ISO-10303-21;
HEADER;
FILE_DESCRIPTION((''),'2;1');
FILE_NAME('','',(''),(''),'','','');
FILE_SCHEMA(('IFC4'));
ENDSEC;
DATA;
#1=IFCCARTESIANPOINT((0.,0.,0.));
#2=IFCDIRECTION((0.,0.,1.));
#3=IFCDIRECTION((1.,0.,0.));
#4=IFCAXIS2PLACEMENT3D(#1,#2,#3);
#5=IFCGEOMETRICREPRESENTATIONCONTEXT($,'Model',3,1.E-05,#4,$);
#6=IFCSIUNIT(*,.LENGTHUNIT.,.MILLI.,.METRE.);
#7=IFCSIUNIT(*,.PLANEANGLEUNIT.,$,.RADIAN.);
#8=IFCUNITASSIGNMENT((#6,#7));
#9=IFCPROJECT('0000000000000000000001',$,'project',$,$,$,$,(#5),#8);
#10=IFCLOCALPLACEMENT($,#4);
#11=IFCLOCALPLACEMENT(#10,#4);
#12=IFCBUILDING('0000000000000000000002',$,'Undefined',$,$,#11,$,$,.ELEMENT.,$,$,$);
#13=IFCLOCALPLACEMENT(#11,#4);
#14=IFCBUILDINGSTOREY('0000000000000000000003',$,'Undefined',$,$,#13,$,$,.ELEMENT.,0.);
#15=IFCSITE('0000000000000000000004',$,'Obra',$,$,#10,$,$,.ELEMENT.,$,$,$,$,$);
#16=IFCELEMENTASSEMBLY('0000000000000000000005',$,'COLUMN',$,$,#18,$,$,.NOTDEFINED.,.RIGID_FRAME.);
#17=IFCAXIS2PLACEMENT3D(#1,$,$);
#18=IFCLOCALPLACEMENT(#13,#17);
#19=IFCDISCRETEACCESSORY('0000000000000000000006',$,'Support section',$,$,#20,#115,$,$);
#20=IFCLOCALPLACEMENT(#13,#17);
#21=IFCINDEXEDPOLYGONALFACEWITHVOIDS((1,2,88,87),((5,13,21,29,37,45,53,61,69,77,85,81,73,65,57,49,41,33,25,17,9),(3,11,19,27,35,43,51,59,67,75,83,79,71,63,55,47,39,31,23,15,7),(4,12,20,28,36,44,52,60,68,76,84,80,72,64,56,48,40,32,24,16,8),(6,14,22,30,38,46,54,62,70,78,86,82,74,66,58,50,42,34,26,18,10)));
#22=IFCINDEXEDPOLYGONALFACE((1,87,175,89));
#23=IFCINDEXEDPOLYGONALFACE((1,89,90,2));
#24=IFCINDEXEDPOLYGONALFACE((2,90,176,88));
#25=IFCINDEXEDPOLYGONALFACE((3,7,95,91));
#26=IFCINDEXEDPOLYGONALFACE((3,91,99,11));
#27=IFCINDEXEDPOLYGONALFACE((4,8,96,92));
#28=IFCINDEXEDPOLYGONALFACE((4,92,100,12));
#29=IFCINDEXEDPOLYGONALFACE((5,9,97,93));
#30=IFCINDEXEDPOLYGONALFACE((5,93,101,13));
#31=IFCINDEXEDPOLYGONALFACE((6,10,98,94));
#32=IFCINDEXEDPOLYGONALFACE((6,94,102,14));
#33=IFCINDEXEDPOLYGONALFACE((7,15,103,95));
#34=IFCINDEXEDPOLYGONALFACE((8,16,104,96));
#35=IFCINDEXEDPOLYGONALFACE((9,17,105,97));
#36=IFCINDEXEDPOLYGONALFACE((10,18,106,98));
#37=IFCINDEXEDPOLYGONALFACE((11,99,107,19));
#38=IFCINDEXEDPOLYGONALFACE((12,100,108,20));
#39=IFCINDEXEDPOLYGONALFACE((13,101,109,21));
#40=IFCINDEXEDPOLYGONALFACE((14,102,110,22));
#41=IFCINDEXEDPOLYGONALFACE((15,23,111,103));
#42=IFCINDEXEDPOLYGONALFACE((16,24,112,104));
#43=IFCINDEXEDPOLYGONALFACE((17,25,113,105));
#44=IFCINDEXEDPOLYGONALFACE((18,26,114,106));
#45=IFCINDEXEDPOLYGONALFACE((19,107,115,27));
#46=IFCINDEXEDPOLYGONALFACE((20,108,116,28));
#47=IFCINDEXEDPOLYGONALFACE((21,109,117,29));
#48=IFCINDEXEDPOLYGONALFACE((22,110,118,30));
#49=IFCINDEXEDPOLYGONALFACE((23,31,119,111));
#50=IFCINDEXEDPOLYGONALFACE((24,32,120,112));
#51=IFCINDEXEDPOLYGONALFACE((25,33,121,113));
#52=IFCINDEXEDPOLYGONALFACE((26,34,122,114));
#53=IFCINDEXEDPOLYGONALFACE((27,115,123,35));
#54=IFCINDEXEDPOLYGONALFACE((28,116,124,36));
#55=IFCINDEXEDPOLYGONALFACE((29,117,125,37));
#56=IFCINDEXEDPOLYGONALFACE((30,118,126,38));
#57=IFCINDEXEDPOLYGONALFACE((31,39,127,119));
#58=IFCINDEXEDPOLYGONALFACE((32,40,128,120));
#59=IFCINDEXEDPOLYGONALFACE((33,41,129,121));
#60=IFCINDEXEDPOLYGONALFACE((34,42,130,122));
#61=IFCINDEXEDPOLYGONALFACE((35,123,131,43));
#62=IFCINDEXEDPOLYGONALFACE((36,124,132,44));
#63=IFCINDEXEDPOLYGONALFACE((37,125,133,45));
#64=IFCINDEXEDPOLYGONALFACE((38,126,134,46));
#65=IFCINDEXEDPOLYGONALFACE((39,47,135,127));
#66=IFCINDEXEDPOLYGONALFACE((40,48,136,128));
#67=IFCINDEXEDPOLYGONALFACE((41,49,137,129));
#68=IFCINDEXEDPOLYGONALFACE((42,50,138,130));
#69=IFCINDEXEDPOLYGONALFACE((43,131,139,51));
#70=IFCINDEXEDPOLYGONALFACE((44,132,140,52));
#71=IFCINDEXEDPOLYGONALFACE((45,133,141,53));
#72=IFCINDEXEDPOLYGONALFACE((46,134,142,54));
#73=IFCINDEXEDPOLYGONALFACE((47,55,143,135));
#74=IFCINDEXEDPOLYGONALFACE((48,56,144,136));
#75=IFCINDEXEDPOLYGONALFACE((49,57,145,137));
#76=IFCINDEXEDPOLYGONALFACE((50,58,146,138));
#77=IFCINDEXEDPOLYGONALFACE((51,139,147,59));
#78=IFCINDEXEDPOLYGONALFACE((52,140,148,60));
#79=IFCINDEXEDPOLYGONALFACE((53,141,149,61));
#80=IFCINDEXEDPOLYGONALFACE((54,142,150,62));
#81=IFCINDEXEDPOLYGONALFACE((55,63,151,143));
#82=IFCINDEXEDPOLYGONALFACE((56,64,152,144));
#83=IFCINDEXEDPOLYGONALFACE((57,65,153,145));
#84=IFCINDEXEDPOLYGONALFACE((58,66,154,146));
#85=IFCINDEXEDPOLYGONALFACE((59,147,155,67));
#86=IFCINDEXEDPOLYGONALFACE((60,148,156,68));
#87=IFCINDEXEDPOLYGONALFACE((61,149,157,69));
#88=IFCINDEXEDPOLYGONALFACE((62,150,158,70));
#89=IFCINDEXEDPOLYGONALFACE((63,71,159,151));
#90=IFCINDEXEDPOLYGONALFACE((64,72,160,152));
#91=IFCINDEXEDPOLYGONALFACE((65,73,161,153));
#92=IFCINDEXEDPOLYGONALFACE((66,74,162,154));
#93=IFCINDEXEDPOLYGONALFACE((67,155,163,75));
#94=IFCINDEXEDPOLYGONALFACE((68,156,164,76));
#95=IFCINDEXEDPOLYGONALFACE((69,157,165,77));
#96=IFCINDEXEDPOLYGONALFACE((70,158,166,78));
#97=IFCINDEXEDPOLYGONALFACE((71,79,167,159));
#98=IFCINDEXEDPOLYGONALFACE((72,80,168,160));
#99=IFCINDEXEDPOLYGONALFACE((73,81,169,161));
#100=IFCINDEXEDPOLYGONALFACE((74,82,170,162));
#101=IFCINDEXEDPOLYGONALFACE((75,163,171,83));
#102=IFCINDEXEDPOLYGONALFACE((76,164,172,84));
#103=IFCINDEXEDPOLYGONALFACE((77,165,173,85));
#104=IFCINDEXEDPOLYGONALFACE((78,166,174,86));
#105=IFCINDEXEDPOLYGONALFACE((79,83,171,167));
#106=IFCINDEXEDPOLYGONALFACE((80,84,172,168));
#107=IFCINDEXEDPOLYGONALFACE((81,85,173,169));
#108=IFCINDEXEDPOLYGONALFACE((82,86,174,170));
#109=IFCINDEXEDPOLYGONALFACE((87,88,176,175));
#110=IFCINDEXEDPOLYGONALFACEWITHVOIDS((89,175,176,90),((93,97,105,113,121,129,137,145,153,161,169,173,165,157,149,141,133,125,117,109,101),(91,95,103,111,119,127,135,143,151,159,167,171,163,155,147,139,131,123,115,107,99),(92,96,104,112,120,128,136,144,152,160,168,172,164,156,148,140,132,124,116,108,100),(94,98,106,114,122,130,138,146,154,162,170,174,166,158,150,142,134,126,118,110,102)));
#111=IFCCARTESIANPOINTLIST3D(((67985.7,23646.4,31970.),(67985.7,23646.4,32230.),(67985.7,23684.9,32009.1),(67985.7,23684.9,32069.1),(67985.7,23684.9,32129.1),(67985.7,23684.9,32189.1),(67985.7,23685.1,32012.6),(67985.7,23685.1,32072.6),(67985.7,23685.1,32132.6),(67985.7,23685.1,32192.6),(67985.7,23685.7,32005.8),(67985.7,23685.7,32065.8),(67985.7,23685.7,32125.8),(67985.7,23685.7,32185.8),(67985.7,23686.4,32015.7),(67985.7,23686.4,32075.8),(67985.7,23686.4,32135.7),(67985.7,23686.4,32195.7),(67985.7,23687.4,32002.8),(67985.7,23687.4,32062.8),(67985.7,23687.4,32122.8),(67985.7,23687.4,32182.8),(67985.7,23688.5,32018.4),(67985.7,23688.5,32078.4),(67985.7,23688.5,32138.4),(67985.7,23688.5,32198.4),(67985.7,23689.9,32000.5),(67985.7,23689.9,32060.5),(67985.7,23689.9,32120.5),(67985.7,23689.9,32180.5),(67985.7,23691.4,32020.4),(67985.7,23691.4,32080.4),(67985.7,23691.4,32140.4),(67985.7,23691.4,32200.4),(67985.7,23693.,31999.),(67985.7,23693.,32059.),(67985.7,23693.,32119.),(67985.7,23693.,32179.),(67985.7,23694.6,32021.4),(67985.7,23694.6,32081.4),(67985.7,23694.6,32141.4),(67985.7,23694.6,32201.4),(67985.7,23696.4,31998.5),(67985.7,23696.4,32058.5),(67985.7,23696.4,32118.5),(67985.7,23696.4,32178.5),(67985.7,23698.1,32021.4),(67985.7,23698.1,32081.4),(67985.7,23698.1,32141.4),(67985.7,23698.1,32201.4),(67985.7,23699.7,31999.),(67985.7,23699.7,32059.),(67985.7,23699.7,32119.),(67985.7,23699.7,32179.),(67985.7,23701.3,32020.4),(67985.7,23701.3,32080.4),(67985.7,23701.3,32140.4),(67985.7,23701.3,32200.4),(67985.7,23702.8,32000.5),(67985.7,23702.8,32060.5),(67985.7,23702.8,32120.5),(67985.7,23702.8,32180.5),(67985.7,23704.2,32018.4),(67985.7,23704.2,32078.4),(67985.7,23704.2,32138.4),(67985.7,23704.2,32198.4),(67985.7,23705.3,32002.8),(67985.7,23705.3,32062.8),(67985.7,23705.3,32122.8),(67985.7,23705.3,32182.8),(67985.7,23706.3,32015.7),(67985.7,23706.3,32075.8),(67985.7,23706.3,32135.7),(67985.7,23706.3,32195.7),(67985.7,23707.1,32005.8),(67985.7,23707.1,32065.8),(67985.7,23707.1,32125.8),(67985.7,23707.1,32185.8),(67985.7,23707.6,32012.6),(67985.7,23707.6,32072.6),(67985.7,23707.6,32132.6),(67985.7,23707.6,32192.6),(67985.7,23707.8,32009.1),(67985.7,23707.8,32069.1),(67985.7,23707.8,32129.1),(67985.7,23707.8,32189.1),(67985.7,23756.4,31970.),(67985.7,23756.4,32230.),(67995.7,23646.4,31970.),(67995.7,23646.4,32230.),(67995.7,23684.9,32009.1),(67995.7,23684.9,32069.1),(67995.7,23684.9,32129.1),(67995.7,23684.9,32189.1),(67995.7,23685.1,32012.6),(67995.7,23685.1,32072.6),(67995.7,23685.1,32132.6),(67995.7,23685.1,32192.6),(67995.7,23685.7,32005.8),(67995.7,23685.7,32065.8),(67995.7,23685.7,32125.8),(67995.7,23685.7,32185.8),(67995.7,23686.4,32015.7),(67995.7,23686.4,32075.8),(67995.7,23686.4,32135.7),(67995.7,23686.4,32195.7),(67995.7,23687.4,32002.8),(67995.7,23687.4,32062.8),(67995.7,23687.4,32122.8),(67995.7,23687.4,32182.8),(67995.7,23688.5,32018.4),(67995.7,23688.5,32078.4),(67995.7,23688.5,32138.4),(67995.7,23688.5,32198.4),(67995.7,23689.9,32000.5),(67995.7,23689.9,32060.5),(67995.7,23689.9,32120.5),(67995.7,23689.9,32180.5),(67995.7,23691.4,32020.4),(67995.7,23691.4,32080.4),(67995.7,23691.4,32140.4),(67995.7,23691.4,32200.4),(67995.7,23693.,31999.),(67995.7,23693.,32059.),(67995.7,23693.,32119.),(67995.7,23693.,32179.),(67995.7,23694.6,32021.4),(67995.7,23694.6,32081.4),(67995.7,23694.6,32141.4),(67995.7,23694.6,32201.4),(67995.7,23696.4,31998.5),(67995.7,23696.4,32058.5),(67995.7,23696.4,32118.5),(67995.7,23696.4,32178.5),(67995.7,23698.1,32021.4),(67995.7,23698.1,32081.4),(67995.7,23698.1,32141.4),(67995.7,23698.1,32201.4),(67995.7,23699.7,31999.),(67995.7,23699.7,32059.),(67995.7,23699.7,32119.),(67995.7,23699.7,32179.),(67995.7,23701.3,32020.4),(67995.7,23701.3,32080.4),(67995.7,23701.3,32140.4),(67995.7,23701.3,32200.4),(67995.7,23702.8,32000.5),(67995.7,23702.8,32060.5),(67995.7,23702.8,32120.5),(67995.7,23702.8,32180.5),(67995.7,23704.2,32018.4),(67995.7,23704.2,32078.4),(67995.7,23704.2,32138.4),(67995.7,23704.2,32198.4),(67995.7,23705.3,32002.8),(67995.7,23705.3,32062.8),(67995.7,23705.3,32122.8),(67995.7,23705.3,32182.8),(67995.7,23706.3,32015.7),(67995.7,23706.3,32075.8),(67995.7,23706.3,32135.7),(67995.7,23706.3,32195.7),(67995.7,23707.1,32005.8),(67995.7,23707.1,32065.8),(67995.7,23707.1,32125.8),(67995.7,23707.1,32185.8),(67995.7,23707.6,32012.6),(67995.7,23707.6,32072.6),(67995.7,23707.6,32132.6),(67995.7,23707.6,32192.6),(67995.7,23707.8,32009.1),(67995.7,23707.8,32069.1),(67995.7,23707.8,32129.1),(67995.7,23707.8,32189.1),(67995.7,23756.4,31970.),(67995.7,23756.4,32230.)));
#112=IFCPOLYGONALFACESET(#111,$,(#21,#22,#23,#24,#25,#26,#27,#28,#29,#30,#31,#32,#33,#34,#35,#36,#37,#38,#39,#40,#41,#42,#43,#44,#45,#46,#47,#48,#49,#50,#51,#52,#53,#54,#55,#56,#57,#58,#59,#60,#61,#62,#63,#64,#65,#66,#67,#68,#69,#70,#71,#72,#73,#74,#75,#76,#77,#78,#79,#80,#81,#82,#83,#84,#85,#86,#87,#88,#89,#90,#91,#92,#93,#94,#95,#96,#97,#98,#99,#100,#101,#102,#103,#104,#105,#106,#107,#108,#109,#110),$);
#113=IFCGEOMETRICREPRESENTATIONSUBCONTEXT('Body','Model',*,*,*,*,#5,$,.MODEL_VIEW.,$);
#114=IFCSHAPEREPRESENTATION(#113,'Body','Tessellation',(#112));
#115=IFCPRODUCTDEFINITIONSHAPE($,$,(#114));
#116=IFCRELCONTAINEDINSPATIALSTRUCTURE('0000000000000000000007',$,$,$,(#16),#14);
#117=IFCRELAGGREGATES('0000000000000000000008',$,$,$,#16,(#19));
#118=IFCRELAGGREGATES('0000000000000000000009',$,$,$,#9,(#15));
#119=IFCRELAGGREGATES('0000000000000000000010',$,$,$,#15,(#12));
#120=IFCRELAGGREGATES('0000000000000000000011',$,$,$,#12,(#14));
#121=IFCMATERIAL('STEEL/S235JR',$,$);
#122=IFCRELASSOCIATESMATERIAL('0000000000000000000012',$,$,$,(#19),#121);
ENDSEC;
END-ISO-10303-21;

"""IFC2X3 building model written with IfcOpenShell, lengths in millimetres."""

from ifc_helpers import new_model, si_unit, frame, origin_with_axes, origin_2d_with_axis, place, context, subcontext, project, spatial, rectangle, circle, extrude, source, transform, mapped, material, element, aggregate, save


model = new_model("IFC2X3")

# Units and contexts
model_context = context("Model", 3, precision=1e-05, world=origin_with_axes())
body_context = subcontext(model_context, "Body", "Model", "MODEL_VIEW")
ifc_project = project(units=[si_unit("LENGTHUNIT", "METRE", prefix="MILLI"), si_unit("PLANEANGLEUNIT", "RADIAN")], contexts=[model_context])

# Site, building, storey
site_placement = place(None, origin_with_axes())
site = spatial("IfcSite", under=ifc_project, at=site_placement, Name="Obra", CompositionType="ELEMENT")
building_placement = place(site_placement, origin_with_axes())
building = spatial("IfcBuilding", under=site, at=building_placement, Name="Undefined", CompositionType="ELEMENT")
storey_placement = place(building_placement, origin_with_axes())
storey = spatial("IfcBuildingStorey", under=building, at=storey_placement, Name="Undefined", CompositionType="ELEMENT", Elevation=0.0)

# Element assembly
assembly_1_placement = place(storey_placement, origin_with_axes())
assembly_1 = element("IfcElementAssembly", 1, at=assembly_1_placement, inside=storey, Name="COLUMN", AssemblyPlace="NOTDEFINED", PredefinedType="RIGID_FRAME")
ifc_material_1 = material(Name="STEEL/S235JR")

# Discrete accessory, opening
shared_shape_1 = source(origin_with_axes(), body_context, "Body", "SweptSolid", [
    extrude(circle(Radius=11.5, at=origin_2d_with_axis()), frame((0.0, -14.4, 0.0), z_axis=(0.0, 1.0, 0.0), x_axis=(1.0, 0.0, 0.0)), (0.0, 0.0, 1.0), 10.2),
])
discrete_accessory_1_placement = place(assembly_1_placement, frame((67990.7, 23701.4, 31970.0), z_axis=(0.0, 0.0, 1.0), x_axis=(0.0, 1.0, 0.0)))
discrete_accessory_1 = element("IfcDiscreteAccessory", 2, at=discrete_accessory_1_placement, material=ifc_material_1, Name="Support section", context=body_context, shape_type="SweptSolid", body=[
    extrude(rectangle(XDim=10.0, YDim=110.0, at=origin_2d_with_axis()), frame((0.0, 0.0, 260.0), z_axis=(0.0, 0.0, -1.0), x_axis=(0.0, 1.0, 0.0)), (0.0, 0.0, 1.0), 260.0),
])
opening_1_placement = place(assembly_1_placement, frame((68000.0, 23746.4, 32300.0), z_axis=(0.0, -1.0, 0.0), x_axis=(0.0, 0.0, -1.0)))
element("IfcOpeningElement", 3, at=opening_1_placement, cuts=discrete_accessory_1, ObjectType="Opening", context=body_context, shape_type="MappedRepresentation", body=[
    mapped(shared_shape_1, transform((110.0, 0.0, 50.0))),
    mapped(shared_shape_1, transform((170.0, 0.0, 50.0))),
    mapped(shared_shape_1, transform((230.0, 0.0, 50.0))),
    mapped(shared_shape_1, transform((290.0, 0.0, 50.0))),
])
aggregate(assembly_1, [discrete_accessory_1])

save(model, "model.ifc")
